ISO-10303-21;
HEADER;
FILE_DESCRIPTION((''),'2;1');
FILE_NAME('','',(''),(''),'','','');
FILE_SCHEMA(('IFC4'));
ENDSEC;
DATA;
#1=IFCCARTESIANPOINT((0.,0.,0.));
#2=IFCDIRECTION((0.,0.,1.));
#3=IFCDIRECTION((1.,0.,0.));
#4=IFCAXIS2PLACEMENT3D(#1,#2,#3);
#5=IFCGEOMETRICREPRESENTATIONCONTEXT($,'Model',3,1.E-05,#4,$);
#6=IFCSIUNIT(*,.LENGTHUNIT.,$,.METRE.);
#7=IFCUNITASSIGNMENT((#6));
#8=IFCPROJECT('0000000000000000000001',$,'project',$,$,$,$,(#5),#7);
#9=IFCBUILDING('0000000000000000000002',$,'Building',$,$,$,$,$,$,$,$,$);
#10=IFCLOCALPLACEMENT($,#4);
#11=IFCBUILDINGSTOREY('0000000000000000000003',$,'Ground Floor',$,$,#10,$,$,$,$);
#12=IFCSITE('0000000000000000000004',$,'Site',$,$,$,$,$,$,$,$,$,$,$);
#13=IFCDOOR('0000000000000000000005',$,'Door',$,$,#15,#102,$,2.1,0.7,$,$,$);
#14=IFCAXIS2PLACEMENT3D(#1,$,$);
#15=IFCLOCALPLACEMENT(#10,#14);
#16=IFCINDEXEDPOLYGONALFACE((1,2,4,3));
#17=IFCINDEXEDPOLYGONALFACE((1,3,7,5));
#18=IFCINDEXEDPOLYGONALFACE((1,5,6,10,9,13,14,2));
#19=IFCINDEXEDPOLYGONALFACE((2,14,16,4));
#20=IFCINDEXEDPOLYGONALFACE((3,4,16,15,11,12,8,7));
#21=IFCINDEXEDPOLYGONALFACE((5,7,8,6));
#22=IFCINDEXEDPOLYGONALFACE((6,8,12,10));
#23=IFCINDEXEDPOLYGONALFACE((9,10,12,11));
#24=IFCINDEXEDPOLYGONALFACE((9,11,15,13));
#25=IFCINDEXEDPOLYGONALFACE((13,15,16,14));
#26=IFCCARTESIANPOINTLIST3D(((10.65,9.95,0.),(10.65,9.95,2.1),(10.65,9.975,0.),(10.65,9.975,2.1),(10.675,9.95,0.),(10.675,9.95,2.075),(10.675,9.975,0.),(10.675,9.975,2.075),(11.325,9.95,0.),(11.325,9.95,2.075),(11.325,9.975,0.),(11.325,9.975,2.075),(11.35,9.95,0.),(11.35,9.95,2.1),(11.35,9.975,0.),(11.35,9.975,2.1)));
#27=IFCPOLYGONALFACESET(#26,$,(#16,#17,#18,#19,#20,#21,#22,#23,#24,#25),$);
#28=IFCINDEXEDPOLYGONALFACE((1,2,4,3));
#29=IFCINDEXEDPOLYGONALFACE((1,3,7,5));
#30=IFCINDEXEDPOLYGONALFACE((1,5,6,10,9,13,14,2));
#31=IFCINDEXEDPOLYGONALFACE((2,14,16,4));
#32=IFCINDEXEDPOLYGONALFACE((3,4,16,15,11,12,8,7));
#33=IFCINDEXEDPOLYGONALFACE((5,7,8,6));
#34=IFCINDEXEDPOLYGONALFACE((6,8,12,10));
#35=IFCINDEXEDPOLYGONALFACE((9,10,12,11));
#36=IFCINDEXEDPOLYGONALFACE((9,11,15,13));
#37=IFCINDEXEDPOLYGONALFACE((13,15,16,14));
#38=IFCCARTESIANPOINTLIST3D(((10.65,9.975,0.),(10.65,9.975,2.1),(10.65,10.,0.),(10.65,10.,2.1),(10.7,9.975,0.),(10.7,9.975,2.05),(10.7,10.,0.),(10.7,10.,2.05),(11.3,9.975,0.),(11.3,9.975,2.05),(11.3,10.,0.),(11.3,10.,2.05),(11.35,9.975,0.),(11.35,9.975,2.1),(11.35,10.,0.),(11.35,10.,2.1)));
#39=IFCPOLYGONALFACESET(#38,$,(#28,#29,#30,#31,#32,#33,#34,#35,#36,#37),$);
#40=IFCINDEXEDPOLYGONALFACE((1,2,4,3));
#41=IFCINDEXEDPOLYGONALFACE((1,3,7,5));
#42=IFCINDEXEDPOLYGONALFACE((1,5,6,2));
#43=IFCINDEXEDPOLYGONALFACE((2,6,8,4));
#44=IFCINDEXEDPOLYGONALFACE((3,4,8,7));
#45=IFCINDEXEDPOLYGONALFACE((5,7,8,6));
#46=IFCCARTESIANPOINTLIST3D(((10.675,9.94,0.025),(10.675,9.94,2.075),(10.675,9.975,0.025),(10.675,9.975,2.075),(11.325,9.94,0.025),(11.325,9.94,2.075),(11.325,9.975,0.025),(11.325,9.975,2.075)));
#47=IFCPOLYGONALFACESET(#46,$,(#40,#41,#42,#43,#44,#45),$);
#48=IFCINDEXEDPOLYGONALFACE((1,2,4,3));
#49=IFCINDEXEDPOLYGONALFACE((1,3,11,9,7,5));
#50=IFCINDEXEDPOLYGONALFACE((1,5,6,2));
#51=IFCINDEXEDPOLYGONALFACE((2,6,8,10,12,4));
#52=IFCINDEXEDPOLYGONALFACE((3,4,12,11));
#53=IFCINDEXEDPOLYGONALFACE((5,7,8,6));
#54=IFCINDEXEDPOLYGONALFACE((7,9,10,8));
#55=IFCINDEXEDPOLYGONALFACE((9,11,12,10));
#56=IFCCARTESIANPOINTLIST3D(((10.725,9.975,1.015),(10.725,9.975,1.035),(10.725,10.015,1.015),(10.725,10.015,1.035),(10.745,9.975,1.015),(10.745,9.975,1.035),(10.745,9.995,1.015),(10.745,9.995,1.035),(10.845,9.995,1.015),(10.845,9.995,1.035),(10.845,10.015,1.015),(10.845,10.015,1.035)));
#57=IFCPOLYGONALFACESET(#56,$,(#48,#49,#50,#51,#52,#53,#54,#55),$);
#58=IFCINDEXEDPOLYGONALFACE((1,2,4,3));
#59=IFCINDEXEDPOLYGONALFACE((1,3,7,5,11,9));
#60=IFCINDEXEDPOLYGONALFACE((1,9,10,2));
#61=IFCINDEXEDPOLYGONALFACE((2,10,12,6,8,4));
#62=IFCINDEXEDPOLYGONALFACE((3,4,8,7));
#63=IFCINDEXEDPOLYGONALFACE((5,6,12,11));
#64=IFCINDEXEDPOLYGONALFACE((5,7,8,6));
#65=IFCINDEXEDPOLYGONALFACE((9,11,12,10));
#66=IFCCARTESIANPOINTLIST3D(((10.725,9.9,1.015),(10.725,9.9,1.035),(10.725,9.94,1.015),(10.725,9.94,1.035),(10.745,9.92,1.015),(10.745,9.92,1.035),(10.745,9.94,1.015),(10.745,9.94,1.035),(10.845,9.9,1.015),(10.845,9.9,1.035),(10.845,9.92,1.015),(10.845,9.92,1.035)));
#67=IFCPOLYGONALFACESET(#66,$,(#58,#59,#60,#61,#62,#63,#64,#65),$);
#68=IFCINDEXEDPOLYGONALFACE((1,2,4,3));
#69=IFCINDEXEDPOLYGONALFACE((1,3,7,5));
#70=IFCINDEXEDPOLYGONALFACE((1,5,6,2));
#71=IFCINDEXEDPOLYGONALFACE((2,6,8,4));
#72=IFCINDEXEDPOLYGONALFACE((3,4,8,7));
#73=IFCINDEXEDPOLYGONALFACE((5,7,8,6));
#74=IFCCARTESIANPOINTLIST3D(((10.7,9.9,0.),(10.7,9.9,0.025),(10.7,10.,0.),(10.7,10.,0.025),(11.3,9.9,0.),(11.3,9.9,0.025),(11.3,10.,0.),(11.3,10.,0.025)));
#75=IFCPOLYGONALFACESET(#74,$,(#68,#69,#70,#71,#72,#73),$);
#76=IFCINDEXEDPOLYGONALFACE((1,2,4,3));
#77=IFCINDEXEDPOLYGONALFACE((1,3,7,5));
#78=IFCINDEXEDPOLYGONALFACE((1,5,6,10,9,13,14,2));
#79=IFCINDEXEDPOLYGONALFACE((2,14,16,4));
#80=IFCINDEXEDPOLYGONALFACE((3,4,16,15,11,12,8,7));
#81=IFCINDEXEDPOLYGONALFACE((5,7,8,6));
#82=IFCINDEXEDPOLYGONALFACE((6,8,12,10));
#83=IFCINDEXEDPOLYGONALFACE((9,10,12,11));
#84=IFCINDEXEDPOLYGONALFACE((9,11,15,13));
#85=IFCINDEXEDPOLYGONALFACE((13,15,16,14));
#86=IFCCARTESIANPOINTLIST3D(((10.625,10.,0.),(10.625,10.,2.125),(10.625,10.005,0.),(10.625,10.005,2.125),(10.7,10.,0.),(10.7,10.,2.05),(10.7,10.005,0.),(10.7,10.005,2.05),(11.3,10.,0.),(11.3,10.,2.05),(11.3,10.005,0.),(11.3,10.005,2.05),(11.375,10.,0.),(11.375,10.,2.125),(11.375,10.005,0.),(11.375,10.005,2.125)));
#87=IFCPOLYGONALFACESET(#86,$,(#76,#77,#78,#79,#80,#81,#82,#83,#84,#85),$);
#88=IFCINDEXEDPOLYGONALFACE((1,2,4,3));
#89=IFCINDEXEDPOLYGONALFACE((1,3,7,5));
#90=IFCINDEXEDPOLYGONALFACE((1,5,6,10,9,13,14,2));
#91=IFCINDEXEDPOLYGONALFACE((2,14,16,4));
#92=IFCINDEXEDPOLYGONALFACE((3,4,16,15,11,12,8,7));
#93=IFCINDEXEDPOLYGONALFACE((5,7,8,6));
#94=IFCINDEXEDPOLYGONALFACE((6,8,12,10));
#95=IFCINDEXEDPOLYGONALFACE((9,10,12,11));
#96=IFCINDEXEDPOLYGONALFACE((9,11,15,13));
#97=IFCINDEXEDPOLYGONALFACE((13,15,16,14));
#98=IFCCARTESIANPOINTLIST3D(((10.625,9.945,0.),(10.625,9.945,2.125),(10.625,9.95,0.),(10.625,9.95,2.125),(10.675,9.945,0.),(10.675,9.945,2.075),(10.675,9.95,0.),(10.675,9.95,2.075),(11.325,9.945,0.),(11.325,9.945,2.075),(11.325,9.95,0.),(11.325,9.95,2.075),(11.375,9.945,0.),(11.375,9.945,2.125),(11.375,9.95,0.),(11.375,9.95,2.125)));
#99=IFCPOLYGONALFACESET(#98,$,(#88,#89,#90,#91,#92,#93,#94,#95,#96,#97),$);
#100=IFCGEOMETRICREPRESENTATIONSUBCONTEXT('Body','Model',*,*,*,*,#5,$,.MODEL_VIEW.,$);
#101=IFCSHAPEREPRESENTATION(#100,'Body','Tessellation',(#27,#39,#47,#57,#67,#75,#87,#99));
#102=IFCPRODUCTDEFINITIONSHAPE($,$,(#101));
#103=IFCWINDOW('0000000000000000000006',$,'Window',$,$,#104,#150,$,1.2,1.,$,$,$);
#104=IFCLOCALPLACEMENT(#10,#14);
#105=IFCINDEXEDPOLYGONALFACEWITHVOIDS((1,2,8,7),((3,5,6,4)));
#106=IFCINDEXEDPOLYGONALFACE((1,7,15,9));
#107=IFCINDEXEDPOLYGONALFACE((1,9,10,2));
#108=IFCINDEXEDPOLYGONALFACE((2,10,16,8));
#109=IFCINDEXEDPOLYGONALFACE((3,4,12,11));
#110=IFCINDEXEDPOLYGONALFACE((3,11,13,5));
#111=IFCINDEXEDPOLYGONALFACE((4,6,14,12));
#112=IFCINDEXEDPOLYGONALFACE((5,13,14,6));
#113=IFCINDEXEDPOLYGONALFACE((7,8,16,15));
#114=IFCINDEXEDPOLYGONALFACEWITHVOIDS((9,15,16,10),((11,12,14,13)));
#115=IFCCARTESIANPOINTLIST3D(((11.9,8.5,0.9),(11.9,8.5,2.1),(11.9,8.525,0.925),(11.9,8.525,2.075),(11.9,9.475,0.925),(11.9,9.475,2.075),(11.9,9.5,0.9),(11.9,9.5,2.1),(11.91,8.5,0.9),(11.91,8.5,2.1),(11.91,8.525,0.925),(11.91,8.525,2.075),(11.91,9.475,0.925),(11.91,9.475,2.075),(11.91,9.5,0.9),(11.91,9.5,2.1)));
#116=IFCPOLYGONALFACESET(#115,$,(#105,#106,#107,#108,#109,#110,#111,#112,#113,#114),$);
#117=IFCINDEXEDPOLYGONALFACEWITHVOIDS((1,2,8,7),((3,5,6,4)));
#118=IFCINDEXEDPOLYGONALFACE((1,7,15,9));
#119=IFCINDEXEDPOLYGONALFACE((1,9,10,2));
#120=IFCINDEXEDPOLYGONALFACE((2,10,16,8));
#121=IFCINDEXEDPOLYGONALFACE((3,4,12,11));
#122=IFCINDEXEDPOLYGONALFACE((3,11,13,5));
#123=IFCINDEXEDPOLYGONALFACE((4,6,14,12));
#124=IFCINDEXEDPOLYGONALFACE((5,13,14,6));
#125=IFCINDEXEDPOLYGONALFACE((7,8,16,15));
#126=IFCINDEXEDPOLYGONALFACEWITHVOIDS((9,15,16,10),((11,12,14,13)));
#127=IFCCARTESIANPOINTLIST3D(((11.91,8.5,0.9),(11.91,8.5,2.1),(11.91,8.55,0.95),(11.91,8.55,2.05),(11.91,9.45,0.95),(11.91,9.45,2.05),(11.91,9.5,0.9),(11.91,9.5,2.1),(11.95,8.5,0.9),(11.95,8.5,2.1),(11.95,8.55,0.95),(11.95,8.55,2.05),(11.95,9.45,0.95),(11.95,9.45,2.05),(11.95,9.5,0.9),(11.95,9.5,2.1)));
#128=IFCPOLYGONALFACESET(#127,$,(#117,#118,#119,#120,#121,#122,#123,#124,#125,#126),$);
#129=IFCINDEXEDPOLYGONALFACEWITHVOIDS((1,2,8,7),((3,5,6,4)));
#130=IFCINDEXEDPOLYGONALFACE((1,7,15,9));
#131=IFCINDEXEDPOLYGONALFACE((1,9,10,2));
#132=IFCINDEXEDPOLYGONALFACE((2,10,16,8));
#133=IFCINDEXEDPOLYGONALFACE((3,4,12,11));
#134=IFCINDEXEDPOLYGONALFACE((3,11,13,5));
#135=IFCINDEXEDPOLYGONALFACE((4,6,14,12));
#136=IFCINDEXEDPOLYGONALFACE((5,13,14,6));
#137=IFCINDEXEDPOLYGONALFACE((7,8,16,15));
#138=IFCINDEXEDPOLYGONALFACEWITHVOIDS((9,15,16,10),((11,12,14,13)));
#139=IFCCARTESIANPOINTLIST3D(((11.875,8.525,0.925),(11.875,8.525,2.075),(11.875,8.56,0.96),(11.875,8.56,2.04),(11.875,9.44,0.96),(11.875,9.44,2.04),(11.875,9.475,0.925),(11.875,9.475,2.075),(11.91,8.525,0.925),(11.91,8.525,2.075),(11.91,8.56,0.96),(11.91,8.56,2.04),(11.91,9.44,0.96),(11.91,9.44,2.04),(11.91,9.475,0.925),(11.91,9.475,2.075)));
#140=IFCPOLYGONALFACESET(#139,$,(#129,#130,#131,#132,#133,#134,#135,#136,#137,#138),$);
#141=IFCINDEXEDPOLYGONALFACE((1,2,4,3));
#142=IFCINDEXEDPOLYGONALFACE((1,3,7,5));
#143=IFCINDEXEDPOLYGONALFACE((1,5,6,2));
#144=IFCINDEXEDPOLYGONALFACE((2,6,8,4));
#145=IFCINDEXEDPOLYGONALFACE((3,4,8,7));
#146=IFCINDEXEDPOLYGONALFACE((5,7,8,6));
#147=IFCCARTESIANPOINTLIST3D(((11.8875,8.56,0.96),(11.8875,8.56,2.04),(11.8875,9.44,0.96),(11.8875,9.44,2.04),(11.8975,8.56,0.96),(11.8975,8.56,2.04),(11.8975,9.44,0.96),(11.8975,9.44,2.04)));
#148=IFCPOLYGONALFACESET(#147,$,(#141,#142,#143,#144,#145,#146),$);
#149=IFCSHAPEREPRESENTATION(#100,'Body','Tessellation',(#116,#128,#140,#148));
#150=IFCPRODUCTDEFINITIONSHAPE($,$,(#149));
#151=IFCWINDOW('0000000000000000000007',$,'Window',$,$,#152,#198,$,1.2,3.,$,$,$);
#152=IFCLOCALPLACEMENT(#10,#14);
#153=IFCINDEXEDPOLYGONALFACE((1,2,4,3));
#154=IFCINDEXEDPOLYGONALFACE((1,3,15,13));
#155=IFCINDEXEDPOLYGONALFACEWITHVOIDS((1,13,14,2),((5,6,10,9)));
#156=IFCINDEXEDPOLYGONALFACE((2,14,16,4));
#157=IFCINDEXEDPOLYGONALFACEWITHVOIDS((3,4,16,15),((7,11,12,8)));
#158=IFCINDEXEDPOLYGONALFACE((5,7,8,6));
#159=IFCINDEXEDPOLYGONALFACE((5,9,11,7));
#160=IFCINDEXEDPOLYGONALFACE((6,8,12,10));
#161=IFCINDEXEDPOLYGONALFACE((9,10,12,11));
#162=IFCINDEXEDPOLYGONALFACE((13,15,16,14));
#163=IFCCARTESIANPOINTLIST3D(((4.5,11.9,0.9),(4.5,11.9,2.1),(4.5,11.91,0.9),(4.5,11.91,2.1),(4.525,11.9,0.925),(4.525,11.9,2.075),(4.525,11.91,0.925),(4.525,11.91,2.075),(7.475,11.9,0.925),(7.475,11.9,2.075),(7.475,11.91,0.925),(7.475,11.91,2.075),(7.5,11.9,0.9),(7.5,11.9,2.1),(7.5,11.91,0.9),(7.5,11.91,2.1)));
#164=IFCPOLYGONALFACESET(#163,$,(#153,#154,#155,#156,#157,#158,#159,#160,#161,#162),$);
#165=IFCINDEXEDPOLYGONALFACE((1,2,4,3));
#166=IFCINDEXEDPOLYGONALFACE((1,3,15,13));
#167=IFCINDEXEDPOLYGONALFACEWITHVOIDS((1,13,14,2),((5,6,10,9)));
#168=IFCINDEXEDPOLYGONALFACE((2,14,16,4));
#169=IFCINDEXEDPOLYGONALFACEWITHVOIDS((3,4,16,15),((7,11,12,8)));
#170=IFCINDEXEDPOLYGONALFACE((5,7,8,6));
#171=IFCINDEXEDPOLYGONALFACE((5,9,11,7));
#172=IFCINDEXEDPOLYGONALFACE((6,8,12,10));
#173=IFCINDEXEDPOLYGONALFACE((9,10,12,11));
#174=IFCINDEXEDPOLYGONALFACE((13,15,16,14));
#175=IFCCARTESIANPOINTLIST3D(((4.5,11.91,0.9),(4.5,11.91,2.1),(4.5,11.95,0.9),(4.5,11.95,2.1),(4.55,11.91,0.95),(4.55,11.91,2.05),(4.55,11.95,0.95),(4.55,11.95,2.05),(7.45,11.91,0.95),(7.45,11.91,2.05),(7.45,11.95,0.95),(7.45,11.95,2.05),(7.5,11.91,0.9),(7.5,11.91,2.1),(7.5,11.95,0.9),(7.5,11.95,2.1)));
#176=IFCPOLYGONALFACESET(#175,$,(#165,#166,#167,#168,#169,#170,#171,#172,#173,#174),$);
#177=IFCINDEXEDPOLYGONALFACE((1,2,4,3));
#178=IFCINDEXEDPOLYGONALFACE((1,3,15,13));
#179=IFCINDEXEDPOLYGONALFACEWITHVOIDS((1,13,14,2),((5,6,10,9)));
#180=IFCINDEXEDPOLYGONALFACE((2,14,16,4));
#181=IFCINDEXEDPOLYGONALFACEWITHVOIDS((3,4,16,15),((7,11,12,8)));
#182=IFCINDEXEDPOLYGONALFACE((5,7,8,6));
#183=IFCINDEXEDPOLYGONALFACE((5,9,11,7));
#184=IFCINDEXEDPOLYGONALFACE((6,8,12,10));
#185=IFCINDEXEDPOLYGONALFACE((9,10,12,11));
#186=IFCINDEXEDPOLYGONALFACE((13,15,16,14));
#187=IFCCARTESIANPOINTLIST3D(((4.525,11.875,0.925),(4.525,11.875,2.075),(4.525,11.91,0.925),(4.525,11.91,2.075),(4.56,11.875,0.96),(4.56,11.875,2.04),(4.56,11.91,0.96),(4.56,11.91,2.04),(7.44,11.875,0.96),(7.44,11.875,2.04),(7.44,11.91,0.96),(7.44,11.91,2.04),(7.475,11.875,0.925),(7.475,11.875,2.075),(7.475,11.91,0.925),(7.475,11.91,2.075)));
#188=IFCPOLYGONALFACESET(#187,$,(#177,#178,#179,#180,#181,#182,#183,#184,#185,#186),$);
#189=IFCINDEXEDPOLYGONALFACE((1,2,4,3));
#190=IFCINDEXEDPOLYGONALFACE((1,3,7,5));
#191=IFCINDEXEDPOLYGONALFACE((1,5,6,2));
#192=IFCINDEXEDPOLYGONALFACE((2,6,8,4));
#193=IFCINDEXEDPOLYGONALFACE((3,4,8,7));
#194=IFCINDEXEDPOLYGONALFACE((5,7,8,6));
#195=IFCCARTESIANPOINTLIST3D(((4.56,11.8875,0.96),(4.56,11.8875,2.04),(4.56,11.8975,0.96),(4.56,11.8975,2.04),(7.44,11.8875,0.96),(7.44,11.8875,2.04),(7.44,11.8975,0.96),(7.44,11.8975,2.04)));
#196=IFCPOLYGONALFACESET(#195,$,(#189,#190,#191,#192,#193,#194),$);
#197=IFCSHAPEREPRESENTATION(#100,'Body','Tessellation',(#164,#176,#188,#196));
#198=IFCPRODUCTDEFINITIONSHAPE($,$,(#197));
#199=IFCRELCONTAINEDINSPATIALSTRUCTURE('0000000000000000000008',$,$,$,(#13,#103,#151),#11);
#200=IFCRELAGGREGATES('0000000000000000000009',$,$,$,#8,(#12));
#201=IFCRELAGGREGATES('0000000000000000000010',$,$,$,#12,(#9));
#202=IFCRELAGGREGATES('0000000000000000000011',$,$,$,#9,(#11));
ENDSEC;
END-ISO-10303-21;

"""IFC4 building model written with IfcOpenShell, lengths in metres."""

from ifc_helpers import new_model, si_unit, frame, origin_with_axes, place, context, subcontext, project, spatial, line, indexed_curve, outline, extrude, element, save


model = new_model("IFC4")

# Units and contexts
model_context = context("Model", 3, precision=1e-05, world=origin_with_axes())
body_context = subcontext(model_context, "Body", "Model", "MODEL_VIEW")
ifc_project = project(units=[si_unit("LENGTHUNIT", "METRE")], contexts=[model_context])

# Site, building, storey
site = spatial("IfcSite", under=ifc_project, Name="Site")
building = spatial("IfcBuilding", under=site, Name="Building")
storey_placement = place(None, origin_with_axes())
storey = spatial("IfcBuildingStorey", under=building, at=storey_placement, Name="Ground Floor")

# Door
door_1_placement = place(storey_placement, frame((11.35, 10.0, 0.0), z_axis=(0.0, 0.0, 1.0), x_axis=(-1.0, 0.0, 0.0)))
element("IfcDoor", 1, at=door_1_placement, inside=storey, Name="Door", OverallHeight=2.1, OverallWidth=0.7, context=body_context, shape_type="SweptSolid", body=[
    extrude(outline(indexed_curve([(0.0, 0.0), (0.0, 2.1), (0.7, 2.1), (0.7, 0.0), (0.675, 0.0), (0.675, 2.075), (0.025, 2.075), (0.025, 0.0)], segments=[line(1, 2, 3, 4, 5, 6, 7, 8, 1)])), frame((0.0, 0.025, 0.0), z_axis=(0.0, -1.0, 0.0), x_axis=(1.0, 0.0, 0.0)), (0.0, 0.0, -1.0), 0.025),
    extrude(outline(indexed_curve([(0.0, 0.0), (0.0, 2.1), (0.7, 2.1), (0.7, 0.0), (0.65, 0.0), (0.65, 2.05), (0.05, 2.05), (0.05, 0.0)], segments=[line(1, 2, 3, 4, 5, 6, 7, 8, 1)])), frame((0.0, 0.0, 0.0), z_axis=(0.0, -1.0, 0.0), x_axis=(1.0, 0.0, 0.0)), (0.0, 0.0, -1.0), 0.025),
    extrude(outline(indexed_curve([(0.0, 0.0), (0.65, 0.0), (0.65, 0.035), (0.0, 0.035)], segments=[line(1, 2, 3, 4, 1)])), frame((0.025, 0.025, 0.025), z_axis=(0.0, 0.0, 1.0), x_axis=(1.0, 0.0, 0.0)), (0.0, 0.0, 1.0), 2.05),
    extrude(outline(indexed_curve([(0.0, 0.0), (0.0, -0.04), (-0.12, -0.04), (-0.12, -0.02), (-0.02, -0.02), (-0.02, 0.0)], segments=[line(1, 2, 3, 4, 5, 6, 1)])), frame((0.625, 0.025, 1.015), z_axis=(0.0, 0.0, 1.0), x_axis=(1.0, 0.0, 0.0)), (0.0, 0.0, 1.0), 0.02),
    extrude(outline(indexed_curve([(0.0, 0.0), (0.0, 0.04), (-0.12, 0.04), (-0.12, 0.02), (-0.02, 0.02), (-0.02, 0.0)], segments=[line(1, 2, 3, 4, 5, 6, 1)])), frame((0.625, 0.06, 1.015), z_axis=(0.0, 0.0, 1.0), x_axis=(1.0, 0.0, 0.0)), (0.0, 0.0, 1.0), 0.02),
    extrude(outline(indexed_curve([(0.0, 0.0), (0.6, 0.0), (0.6, 0.1), (0.0, 0.1)], segments=[line(1, 2, 3, 4, 1)])), frame((0.05, 0.0, 0.0), z_axis=(0.0, 0.0, 1.0), x_axis=(1.0, 0.0, 0.0)), (0.0, 0.0, 1.0), 0.025),
    extrude(outline(indexed_curve([(0.0, 0.0), (0.0, 2.125), (0.75, 2.125), (0.75, 0.0), (0.675, 0.0), (0.675, 2.05), (0.075, 2.05), (0.075, 0.0)], segments=[line(1, 2, 3, 4, 5, 6, 7, 8, 1)])), frame((-0.025, -0.005, 0.0), z_axis=(0.0, -1.0, 0.0), x_axis=(1.0, 0.0, 0.0)), (0.0, 0.0, -1.0), 0.005),
    extrude(outline(indexed_curve([(0.0, 0.0), (0.0, 2.125), (0.75, 2.125), (0.75, 0.0), (0.7, 0.0), (0.7, 2.075), (0.05, 2.075), (0.05, 0.0)], segments=[line(1, 2, 3, 4, 5, 6, 7, 8, 1)])), frame((-0.025, 0.05, 0.0), z_axis=(0.0, -1.0, 0.0), x_axis=(1.0, 0.0, 0.0)), (0.0, 0.0, -1.0), 0.005),
])

# Windows
window_1_placement = place(storey_placement, frame((12.0, 8.5, 0.9), z_axis=(0.0, 0.0, 1.0), x_axis=(0.0, 1.0, 0.0)))
element("IfcWindow", 2, at=window_1_placement, inside=storey, Name="Window", OverallHeight=1.2, OverallWidth=1.0, context=body_context, shape_type="SweptSolid", body=[
    extrude(outline(indexed_curve([(0.0, 0.0), (1.0, 0.0), (1.0, 1.2), (0.0, 1.2)], segments=[line(1, 2, 3, 4, 1)]), holes=[indexed_curve([(0.025, 0.025), (0.975, 0.025), (0.975, 1.175), (0.025, 1.175)], segments=[line(1, 2, 3, 4, 1)])]), frame((0.0, 0.09, 0.0), z_axis=(0.0, -1.0, 0.0), x_axis=(1.0, 0.0, 0.0)), (0.0, 0.0, -1.0), 0.01),
    extrude(outline(indexed_curve([(0.0, 0.0), (1.0, 0.0), (1.0, 1.2), (0.0, 1.2)], segments=[line(1, 2, 3, 4, 1)]), holes=[indexed_curve([(0.05, 0.05), (0.95, 0.05), (0.95, 1.15), (0.05, 1.15)], segments=[line(1, 2, 3, 4, 1)])]), frame((0.0, 0.05, 0.0), z_axis=(0.0, -1.0, 0.0), x_axis=(1.0, 0.0, 0.0)), (0.0, 0.0, -1.0), 0.04),
    extrude(outline(indexed_curve([(0.0, 0.0), (0.95, 0.0), (0.95, 1.15), (0.0, 1.15)], segments=[line(1, 2, 3, 4, 1)]), holes=[indexed_curve([(0.035, 0.035), (0.915, 0.035), (0.915, 1.115), (0.035, 1.115)], segments=[line(1, 2, 3, 4, 1)])]), frame((0.025, 0.09, 0.025), z_axis=(0.0, -1.0, 0.0), x_axis=(1.0, 0.0, 0.0)), (0.0, 0.0, -1.0), 0.035),
    extrude(outline(indexed_curve([(0.035, 0.035), (0.915, 0.035), (0.915, 1.115), (0.035, 1.115)], segments=[line(1, 2, 3, 4, 1)])), frame((0.025, 0.1025, 0.025), z_axis=(0.0, -1.0, 0.0), x_axis=(1.0, 0.0, 0.0)), (0.0, 0.0, -1.0), 0.01),
])
window_2_placement = place(storey_placement, frame((7.5, 12.0, 0.9), z_axis=(0.0, 0.0, 1.0), x_axis=(-1.0, 0.0, 0.0)))
element("IfcWindow", 3, at=window_2_placement, inside=storey, Name="Window", OverallHeight=1.2, OverallWidth=3.0, context=body_context, shape_type="SweptSolid", body=[
    extrude(outline(indexed_curve([(0.0, 0.0), (3.0, 0.0), (3.0, 1.2), (0.0, 1.2)], segments=[line(1, 2, 3, 4, 1)]), holes=[indexed_curve([(0.025, 0.025), (2.975, 0.025), (2.975, 1.175), (0.025, 1.175)], segments=[line(1, 2, 3, 4, 1)])]), frame((0.0, 0.09, 0.0), z_axis=(0.0, -1.0, 0.0), x_axis=(1.0, 0.0, 0.0)), (0.0, 0.0, -1.0), 0.01),
    extrude(outline(indexed_curve([(0.0, 0.0), (3.0, 0.0), (3.0, 1.2), (0.0, 1.2)], segments=[line(1, 2, 3, 4, 1)]), holes=[indexed_curve([(0.05, 0.05), (2.95, 0.05), (2.95, 1.15), (0.05, 1.15)], segments=[line(1, 2, 3, 4, 1)])]), frame((0.0, 0.05, 0.0), z_axis=(0.0, -1.0, 0.0), x_axis=(1.0, 0.0, 0.0)), (0.0, 0.0, -1.0), 0.04),
    extrude(outline(indexed_curve([(0.0, 0.0), (2.95, 0.0), (2.95, 1.15), (0.0, 1.15)], segments=[line(1, 2, 3, 4, 1)]), holes=[indexed_curve([(0.035, 0.035), (2.915, 0.035), (2.915, 1.115), (0.035, 1.115)], segments=[line(1, 2, 3, 4, 1)])]), frame((0.025, 0.09, 0.025), z_axis=(0.0, -1.0, 0.0), x_axis=(1.0, 0.0, 0.0)), (0.0, 0.0, -1.0), 0.035),
    extrude(outline(indexed_curve([(0.035, 0.035), (2.915, 0.035), (2.915, 1.115), (0.035, 1.115)], segments=[line(1, 2, 3, 4, 1)])), frame((0.025, 0.1025, 0.025), z_axis=(0.0, -1.0, 0.0), x_axis=(1.0, 0.0, 0.0)), (0.0, 0.0, -1.0), 0.01),
])

save(model, "model.ifc")
